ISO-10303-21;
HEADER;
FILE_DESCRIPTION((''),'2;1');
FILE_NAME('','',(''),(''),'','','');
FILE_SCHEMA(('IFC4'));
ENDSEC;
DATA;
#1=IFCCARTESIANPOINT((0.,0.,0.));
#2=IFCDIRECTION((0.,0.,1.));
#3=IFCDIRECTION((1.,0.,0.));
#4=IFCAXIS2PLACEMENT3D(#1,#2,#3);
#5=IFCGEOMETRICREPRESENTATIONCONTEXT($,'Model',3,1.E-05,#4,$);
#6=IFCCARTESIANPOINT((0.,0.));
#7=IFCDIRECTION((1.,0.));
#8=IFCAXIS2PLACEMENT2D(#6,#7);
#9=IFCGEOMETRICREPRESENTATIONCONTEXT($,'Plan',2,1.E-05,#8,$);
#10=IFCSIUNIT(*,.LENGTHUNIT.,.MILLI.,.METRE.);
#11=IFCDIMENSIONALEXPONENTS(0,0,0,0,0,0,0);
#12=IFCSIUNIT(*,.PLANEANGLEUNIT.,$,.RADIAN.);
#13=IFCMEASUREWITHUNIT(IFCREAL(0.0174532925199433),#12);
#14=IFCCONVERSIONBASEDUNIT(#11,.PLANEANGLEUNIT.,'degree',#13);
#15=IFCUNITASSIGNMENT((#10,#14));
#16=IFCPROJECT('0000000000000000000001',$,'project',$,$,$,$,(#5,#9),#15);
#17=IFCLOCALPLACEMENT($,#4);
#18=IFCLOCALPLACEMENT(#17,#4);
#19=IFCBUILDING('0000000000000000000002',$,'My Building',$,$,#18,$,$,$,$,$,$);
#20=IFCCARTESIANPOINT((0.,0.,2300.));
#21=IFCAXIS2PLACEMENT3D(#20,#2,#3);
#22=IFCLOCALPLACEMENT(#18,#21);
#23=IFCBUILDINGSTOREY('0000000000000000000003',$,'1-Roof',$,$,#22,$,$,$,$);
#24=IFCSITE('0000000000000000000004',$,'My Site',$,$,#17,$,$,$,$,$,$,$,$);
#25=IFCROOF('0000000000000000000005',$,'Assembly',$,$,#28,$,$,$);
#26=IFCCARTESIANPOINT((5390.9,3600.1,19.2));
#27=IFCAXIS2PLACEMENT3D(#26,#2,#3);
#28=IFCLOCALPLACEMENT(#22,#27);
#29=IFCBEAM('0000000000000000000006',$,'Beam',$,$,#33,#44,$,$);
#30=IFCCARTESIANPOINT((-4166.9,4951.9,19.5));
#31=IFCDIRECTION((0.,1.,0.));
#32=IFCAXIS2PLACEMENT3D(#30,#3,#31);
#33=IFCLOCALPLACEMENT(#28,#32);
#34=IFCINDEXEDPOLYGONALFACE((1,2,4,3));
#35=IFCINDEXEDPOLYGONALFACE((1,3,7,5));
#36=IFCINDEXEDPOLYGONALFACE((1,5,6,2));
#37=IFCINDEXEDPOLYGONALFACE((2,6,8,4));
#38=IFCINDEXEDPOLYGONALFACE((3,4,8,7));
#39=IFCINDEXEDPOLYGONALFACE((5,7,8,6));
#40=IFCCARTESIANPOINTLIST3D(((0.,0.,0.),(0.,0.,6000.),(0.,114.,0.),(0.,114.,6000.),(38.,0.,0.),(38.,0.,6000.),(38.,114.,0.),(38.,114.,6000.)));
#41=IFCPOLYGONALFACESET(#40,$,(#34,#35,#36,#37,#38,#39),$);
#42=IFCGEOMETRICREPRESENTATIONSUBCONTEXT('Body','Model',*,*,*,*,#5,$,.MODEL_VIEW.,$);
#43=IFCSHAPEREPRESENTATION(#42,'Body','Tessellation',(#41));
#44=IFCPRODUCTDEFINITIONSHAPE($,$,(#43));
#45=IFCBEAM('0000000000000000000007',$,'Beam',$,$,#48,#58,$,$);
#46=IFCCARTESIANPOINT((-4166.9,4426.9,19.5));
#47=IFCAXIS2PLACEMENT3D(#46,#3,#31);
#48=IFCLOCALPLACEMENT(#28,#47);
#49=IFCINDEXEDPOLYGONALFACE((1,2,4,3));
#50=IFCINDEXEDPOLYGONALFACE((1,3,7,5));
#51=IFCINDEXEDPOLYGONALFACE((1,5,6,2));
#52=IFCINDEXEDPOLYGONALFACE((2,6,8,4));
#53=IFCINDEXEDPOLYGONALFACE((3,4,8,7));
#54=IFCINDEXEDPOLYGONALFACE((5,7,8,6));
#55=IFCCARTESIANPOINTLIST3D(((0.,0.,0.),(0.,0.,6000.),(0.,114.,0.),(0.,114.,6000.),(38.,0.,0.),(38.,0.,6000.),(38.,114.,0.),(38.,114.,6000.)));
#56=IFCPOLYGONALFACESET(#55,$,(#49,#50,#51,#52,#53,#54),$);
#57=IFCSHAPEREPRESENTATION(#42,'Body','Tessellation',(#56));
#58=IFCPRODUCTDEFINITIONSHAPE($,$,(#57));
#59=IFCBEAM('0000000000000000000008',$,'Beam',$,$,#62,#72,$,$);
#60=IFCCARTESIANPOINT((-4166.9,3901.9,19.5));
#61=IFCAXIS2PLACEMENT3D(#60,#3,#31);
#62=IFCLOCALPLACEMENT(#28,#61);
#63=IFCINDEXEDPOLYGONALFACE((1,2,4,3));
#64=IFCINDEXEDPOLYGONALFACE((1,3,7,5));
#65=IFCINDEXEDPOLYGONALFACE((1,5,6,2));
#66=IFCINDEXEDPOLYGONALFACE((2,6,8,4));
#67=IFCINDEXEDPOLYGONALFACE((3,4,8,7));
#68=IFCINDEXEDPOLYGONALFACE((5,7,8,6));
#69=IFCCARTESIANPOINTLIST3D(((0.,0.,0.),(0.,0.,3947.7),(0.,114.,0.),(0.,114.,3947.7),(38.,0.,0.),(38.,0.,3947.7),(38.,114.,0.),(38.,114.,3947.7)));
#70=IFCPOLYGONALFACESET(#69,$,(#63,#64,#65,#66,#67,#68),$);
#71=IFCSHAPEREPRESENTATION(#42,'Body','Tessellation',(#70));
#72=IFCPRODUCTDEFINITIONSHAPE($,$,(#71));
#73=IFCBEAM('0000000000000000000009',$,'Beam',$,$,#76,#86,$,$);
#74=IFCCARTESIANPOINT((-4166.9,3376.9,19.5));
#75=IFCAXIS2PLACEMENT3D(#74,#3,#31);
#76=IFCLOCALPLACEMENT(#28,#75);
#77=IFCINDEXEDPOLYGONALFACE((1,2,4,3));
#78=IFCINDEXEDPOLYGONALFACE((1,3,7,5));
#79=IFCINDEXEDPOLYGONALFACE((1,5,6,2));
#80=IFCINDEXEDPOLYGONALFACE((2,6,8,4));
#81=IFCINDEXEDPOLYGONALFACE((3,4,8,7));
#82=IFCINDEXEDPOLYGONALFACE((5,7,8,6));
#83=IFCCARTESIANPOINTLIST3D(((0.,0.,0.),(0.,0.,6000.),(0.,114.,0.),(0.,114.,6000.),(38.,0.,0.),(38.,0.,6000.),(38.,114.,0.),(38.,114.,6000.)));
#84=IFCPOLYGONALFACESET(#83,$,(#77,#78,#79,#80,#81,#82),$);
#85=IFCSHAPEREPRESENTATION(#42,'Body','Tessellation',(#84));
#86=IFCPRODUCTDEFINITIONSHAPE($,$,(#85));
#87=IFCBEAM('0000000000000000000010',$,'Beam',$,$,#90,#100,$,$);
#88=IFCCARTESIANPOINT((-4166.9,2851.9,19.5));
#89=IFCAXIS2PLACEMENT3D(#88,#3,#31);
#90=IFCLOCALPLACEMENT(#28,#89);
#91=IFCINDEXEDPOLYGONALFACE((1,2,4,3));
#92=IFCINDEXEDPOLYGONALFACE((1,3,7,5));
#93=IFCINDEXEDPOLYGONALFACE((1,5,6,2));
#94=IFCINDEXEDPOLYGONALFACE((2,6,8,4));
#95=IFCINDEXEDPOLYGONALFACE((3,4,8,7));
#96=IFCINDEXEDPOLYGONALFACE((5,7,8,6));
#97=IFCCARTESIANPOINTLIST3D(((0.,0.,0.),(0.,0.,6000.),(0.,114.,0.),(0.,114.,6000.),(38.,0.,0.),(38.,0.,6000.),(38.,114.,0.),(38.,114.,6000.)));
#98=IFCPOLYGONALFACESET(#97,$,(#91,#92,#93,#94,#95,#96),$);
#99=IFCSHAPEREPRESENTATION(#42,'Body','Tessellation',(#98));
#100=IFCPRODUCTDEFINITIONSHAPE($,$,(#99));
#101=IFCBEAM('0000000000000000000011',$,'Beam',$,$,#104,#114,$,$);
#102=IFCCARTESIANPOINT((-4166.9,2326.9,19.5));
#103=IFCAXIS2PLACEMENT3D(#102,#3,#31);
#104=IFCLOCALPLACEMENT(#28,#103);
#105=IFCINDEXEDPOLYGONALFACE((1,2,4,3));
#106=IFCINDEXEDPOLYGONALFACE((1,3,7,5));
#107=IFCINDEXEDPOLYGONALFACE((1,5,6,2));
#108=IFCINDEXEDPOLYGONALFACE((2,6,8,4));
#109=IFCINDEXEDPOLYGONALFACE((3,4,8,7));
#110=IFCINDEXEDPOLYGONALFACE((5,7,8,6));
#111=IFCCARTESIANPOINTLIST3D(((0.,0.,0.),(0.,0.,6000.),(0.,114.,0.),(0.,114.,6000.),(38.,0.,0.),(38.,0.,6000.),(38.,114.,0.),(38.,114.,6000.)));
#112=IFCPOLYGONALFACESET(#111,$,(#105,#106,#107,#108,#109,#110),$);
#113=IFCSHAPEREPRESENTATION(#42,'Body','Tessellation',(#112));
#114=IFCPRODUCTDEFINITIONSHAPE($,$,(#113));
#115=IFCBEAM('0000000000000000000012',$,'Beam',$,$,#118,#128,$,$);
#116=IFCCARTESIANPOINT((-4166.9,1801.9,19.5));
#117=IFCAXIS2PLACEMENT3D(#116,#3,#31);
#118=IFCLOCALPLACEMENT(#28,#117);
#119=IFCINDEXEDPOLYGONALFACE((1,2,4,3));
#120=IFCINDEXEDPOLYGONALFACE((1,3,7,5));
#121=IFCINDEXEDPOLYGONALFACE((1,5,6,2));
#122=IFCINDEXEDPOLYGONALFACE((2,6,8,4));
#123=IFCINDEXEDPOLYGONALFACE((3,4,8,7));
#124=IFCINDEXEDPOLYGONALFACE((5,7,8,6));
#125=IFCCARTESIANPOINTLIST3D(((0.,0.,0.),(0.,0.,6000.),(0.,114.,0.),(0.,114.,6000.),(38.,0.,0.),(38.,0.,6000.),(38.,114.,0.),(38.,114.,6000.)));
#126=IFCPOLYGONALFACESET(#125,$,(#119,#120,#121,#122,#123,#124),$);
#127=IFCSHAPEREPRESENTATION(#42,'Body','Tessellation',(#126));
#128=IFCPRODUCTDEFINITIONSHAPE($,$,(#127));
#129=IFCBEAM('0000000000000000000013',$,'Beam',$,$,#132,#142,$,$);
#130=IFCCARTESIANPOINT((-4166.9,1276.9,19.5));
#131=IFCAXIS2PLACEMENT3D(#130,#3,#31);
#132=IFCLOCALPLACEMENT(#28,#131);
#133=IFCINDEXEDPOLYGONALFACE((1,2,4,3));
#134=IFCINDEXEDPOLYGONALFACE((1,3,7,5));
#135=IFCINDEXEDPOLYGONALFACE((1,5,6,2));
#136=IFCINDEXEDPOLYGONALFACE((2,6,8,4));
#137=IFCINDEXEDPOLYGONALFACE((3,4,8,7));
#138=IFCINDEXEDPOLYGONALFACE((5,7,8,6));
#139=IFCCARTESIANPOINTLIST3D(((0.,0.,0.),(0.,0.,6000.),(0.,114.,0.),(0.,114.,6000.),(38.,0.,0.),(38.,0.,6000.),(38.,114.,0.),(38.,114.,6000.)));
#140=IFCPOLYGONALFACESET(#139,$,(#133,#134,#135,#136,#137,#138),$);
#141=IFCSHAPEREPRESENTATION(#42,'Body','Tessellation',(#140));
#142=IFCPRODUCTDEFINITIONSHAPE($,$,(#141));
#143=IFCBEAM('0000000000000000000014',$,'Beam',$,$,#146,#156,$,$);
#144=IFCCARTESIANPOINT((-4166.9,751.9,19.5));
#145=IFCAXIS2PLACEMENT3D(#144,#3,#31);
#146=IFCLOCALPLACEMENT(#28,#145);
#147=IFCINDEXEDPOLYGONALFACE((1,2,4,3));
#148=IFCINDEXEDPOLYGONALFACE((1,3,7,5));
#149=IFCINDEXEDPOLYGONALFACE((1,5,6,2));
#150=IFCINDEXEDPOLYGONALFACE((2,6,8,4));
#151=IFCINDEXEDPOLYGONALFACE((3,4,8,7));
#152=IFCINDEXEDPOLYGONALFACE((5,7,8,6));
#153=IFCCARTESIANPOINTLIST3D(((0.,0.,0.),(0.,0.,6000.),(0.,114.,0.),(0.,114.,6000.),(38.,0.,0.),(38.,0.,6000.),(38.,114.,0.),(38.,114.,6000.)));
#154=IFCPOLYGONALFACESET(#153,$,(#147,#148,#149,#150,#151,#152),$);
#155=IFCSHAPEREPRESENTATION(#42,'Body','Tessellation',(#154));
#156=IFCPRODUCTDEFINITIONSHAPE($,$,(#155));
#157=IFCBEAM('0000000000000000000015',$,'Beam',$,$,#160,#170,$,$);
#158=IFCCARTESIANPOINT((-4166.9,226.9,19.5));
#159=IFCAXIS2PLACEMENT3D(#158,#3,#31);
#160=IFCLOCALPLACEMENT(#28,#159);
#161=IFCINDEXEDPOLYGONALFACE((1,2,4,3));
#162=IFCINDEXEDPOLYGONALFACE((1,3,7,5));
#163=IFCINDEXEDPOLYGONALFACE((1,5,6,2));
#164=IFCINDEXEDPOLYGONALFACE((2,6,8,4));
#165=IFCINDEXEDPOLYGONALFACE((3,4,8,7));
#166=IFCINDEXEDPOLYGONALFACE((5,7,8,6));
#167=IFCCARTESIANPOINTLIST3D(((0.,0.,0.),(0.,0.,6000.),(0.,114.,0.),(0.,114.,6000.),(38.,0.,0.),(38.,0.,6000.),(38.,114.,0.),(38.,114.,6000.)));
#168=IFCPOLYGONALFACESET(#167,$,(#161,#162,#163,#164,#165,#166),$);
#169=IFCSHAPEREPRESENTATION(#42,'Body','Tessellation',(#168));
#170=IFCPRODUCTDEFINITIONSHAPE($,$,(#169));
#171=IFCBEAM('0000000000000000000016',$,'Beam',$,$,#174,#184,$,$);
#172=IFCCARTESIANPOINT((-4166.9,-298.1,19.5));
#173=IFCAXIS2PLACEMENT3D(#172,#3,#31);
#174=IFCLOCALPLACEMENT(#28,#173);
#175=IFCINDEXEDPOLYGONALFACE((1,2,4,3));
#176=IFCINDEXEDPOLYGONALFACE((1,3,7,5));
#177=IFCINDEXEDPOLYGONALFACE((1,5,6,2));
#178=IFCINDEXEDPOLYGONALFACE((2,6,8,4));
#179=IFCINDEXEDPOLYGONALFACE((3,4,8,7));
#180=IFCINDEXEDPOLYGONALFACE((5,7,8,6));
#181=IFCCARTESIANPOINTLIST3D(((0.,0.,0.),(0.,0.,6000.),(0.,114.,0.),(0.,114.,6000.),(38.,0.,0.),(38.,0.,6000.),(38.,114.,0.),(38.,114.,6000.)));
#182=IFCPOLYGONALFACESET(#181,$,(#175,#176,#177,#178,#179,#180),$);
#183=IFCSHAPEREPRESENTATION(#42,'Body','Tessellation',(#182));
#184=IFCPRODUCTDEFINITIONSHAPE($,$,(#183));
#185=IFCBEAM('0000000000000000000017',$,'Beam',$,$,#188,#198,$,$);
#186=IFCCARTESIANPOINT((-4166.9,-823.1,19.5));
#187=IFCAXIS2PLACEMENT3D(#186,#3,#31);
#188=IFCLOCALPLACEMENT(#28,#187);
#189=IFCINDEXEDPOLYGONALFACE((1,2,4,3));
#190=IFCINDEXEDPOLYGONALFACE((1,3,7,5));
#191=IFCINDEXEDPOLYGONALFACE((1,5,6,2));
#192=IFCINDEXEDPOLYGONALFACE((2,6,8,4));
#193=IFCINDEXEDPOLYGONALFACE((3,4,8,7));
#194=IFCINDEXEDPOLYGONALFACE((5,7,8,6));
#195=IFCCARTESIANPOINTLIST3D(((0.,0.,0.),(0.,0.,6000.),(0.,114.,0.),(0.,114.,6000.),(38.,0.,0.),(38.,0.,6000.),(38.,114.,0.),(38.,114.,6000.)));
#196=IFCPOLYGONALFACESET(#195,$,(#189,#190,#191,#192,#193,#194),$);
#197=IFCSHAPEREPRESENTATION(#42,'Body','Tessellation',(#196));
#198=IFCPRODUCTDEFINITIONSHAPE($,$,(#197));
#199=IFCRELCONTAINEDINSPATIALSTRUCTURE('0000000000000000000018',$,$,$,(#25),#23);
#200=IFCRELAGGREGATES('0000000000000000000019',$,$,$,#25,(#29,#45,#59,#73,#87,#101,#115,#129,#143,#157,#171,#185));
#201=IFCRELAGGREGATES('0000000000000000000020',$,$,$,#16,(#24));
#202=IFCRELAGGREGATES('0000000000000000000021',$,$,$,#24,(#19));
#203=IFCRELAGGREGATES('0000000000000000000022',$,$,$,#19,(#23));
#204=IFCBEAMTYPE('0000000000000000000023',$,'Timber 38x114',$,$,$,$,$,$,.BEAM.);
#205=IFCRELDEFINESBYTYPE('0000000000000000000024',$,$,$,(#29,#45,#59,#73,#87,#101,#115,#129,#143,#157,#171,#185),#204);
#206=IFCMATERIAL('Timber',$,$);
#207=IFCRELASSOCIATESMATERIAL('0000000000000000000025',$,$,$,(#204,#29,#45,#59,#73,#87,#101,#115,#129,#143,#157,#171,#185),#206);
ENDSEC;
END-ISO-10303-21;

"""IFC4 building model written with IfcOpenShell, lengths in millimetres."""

from ifc_helpers import new_model, entity, si_unit, converted_unit, frame, origin_with_axes, origin_2d_with_axis, place, context, subcontext, project, spatial, line, indexed_curve, outline, extrude, material, material_profile, profile_set, profile_usage, type_object, element, aggregate, save


model = new_model("IFC4")

# Units and contexts
model_context = context("Model", 3, precision=1e-05, world=origin_with_axes())
plan_context = context("Plan", 2, precision=1e-05, world=origin_2d_with_axis())
body_context = subcontext(model_context, "Body", "Model", "MODEL_VIEW")
ifc_project = project(units=[si_unit("LENGTHUNIT", "METRE", prefix="MILLI"), converted_unit("PLANEANGLEUNIT", "degree", entity("IfcReal", 0.0174532925199433), si_unit("PLANEANGLEUNIT", "RADIAN"), dimensions=[0, 0, 0, 0, 0, 0, 0])], contexts=[model_context, plan_context])

# Site, building, storey
site_placement = place(None, origin_with_axes())
site = spatial("IfcSite", under=ifc_project, at=site_placement, Name="My Site")
building_placement = place(site_placement, origin_with_axes())
building = spatial("IfcBuilding", under=site, at=building_placement, Name="My Building")
storey_placement = place(building_placement, frame((0.0, 0.0, 2300.0), z_axis=(0.0, 0.0, 1.0), x_axis=(1.0, 0.0, 0.0)))
storey = spatial("IfcBuildingStorey", under=building, at=storey_placement, Name="1-Roof")

# Roof, beams
roof_placement = place(storey_placement, frame((5390.9, 3600.1, 19.2), z_axis=(0.0, 0.0, 1.0), x_axis=(1.0, 0.0, 0.0)))
roof = element("IfcRoof", 1, at=roof_placement, inside=storey, Name="Assembly")
ifc_material_1 = material(Name="Timber")
ifc_material_profile_1 = material_profile(ifc_material_1, outline(indexed_curve([(0.0, 0.0), (38.0, 0.0), (38.0, 114.0), (0.0, 114.0)], segments=[line(3, 2), line(2, 1), line(1, 4), line(4, 3)], self_intersect=False)))
ifc_profile_set_1 = profile_set([ifc_material_profile_1])
ifc_profile_usage_1 = profile_usage(ifc_profile_set_1, cardinal=5)
beam_type_1 = type_object("IfcBeamType", Name="Timber 38x114", PredefinedType="BEAM", material=ifc_profile_set_1)
beam_1_placement = place(roof_placement, frame((-4166.9, 4951.9, 19.5), z_axis=(1.0, 0.0, 0.0), x_axis=(0.0, 1.0, 0.0)))
beam_1 = element("IfcBeam", 2, at=beam_1_placement, type_object=beam_type_1, material=ifc_profile_usage_1, Name="Beam", context=body_context, shape_type="SweptSolid", body=[
    extrude(outline(indexed_curve([(0.0, 0.0), (38.0, 0.0), (38.0, 114.0), (0.0, 114.0)], segments=[line(3, 2), line(2, 1), line(1, 4), line(4, 3)], self_intersect=False)), origin_with_axes(), (0.0, 0.0, 1.0), 6000.0),
])
ifc_profile_usage_2 = profile_usage(ifc_profile_set_1, cardinal=5)
beam_2_placement = place(roof_placement, frame((-4166.9, 4426.9, 19.5), z_axis=(1.0, 0.0, 0.0), x_axis=(0.0, 1.0, 0.0)))
beam_2 = element("IfcBeam", 3, at=beam_2_placement, type_object=beam_type_1, material=ifc_profile_usage_2, Name="Beam", context=body_context, shape_type="SweptSolid", body=[
    extrude(outline(indexed_curve([(0.0, 0.0), (38.0, 0.0), (38.0, 114.0), (0.0, 114.0)], segments=[line(3, 2), line(2, 1), line(1, 4), line(4, 3)], self_intersect=False)), origin_with_axes(), (0.0, 0.0, 1.0), 6000.0),
])
ifc_profile_usage_3 = profile_usage(ifc_profile_set_1, cardinal=5)
beam_3_placement = place(roof_placement, frame((-4166.9, 3901.9, 19.5), z_axis=(1.0, 0.0, 0.0), x_axis=(0.0, 1.0, 0.0)))
beam_3 = element("IfcBeam", 4, at=beam_3_placement, type_object=beam_type_1, material=ifc_profile_usage_3, Name="Beam", context=body_context, shape_type="SweptSolid", body=[
    extrude(outline(indexed_curve([(0.0, 0.0), (38.0, 0.0), (38.0, 114.0), (0.0, 114.0)], segments=[line(3, 2), line(2, 1), line(1, 4), line(4, 3)], self_intersect=False)), origin_with_axes(), (0.0, 0.0, 1.0), 3947.7),
])
ifc_profile_usage_4 = profile_usage(ifc_profile_set_1, cardinal=5)
beam_4_placement = place(roof_placement, frame((-4166.9, 3376.9, 19.5), z_axis=(1.0, 0.0, 0.0), x_axis=(0.0, 1.0, 0.0)))
beam_4 = element("IfcBeam", 5, at=beam_4_placement, type_object=beam_type_1, material=ifc_profile_usage_4, Name="Beam", context=body_context, shape_type="SweptSolid", body=[
    extrude(outline(indexed_curve([(0.0, 0.0), (38.0, 0.0), (38.0, 114.0), (0.0, 114.0)], segments=[line(3, 2), line(2, 1), line(1, 4), line(4, 3)], self_intersect=False)), origin_with_axes(), (0.0, 0.0, 1.0), 6000.0),
])
ifc_profile_usage_5 = profile_usage(ifc_profile_set_1, cardinal=5)
beam_5_placement = place(roof_placement, frame((-4166.9, 2851.9, 19.5), z_axis=(1.0, 0.0, 0.0), x_axis=(0.0, 1.0, 0.0)))
beam_5 = element("IfcBeam", 6, at=beam_5_placement, type_object=beam_type_1, material=ifc_profile_usage_5, Name="Beam", context=body_context, shape_type="SweptSolid", body=[
    extrude(outline(indexed_curve([(0.0, 0.0), (38.0, 0.0), (38.0, 114.0), (0.0, 114.0)], segments=[line(3, 2), line(2, 1), line(1, 4), line(4, 3)], self_intersect=False)), origin_with_axes(), (0.0, 0.0, 1.0), 6000.0),
])
ifc_profile_usage_6 = profile_usage(ifc_profile_set_1, cardinal=5)
beam_6_placement = place(roof_placement, frame((-4166.9, 2326.9, 19.5), z_axis=(1.0, 0.0, 0.0), x_axis=(0.0, 1.0, 0.0)))
beam_6 = element("IfcBeam", 7, at=beam_6_placement, type_object=beam_type_1, material=ifc_profile_usage_6, Name="Beam", context=body_context, shape_type="SweptSolid", body=[
    extrude(outline(indexed_curve([(0.0, 0.0), (38.0, 0.0), (38.0, 114.0), (0.0, 114.0)], segments=[line(3, 2), line(2, 1), line(1, 4), line(4, 3)], self_intersect=False)), origin_with_axes(), (0.0, 0.0, 1.0), 6000.0),
])
ifc_profile_usage_7 = profile_usage(ifc_profile_set_1, cardinal=5)
beam_7_placement = place(roof_placement, frame((-4166.9, 1801.9, 19.5), z_axis=(1.0, 0.0, 0.0), x_axis=(0.0, 1.0, 0.0)))
beam_7 = element("IfcBeam", 8, at=beam_7_placement, type_object=beam_type_1, material=ifc_profile_usage_7, Name="Beam", context=body_context, shape_type="SweptSolid", body=[
    extrude(outline(indexed_curve([(0.0, 0.0), (38.0, 0.0), (38.0, 114.0), (0.0, 114.0)], segments=[line(3, 2), line(2, 1), line(1, 4), line(4, 3)], self_intersect=False)), origin_with_axes(), (0.0, 0.0, 1.0), 6000.0),
])
ifc_profile_usage_8 = profile_usage(ifc_profile_set_1, cardinal=5)
beam_8_placement = place(roof_placement, frame((-4166.9, 1276.9, 19.5), z_axis=(1.0, 0.0, 0.0), x_axis=(0.0, 1.0, 0.0)))
beam_8 = element("IfcBeam", 9, at=beam_8_placement, type_object=beam_type_1, material=ifc_profile_usage_8, Name="Beam", context=body_context, shape_type="SweptSolid", body=[
    extrude(outline(indexed_curve([(0.0, 0.0), (38.0, 0.0), (38.0, 114.0), (0.0, 114.0)], segments=[line(3, 2), line(2, 1), line(1, 4), line(4, 3)], self_intersect=False)), origin_with_axes(), (0.0, 0.0, 1.0), 6000.0),
])
ifc_profile_usage_9 = profile_usage(ifc_profile_set_1, cardinal=5)
beam_9_placement = place(roof_placement, frame((-4166.9, 751.9, 19.5), z_axis=(1.0, 0.0, 0.0), x_axis=(0.0, 1.0, 0.0)))
beam_9 = element("IfcBeam", 10, at=beam_9_placement, type_object=beam_type_1, material=ifc_profile_usage_9, Name="Beam", context=body_context, shape_type="SweptSolid", body=[
    extrude(outline(indexed_curve([(0.0, 0.0), (38.0, 0.0), (38.0, 114.0), (0.0, 114.0)], segments=[line(3, 2), line(2, 1), line(1, 4), line(4, 3)], self_intersect=False)), origin_with_axes(), (0.0, 0.0, 1.0), 6000.0),
])
ifc_profile_usage_10 = profile_usage(ifc_profile_set_1, cardinal=5)
beam_10_placement = place(roof_placement, frame((-4166.9, 226.9, 19.5), z_axis=(1.0, 0.0, 0.0), x_axis=(0.0, 1.0, 0.0)))
beam_10 = element("IfcBeam", 11, at=beam_10_placement, type_object=beam_type_1, material=ifc_profile_usage_10, Name="Beam", context=body_context, shape_type="SweptSolid", body=[
    extrude(outline(indexed_curve([(0.0, 0.0), (38.0, 0.0), (38.0, 114.0), (0.0, 114.0)], segments=[line(3, 2), line(2, 1), line(1, 4), line(4, 3)], self_intersect=False)), origin_with_axes(), (0.0, 0.0, 1.0), 6000.0),
])
ifc_profile_usage_11 = profile_usage(ifc_profile_set_1, cardinal=5)
beam_11_placement = place(roof_placement, frame((-4166.9, -298.1, 19.5), z_axis=(1.0, 0.0, 0.0), x_axis=(0.0, 1.0, 0.0)))
beam_11 = element("IfcBeam", 12, at=beam_11_placement, type_object=beam_type_1, material=ifc_profile_usage_11, Name="Beam", context=body_context, shape_type="SweptSolid", body=[
    extrude(outline(indexed_curve([(0.0, 0.0), (38.0, 0.0), (38.0, 114.0), (0.0, 114.0)], segments=[line(3, 2), line(2, 1), line(1, 4), line(4, 3)], self_intersect=False)), origin_with_axes(), (0.0, 0.0, 1.0), 6000.0),
])
ifc_profile_usage_12 = profile_usage(ifc_profile_set_1, cardinal=5)
beam_12_placement = place(roof_placement, frame((-4166.9, -823.1, 19.5), z_axis=(1.0, 0.0, 0.0), x_axis=(0.0, 1.0, 0.0)))
beam_12 = element("IfcBeam", 13, at=beam_12_placement, type_object=beam_type_1, material=ifc_profile_usage_12, Name="Beam", context=body_context, shape_type="SweptSolid", body=[
    extrude(outline(indexed_curve([(0.0, 0.0), (38.0, 0.0), (38.0, 114.0), (0.0, 114.0)], segments=[line(3, 2), line(2, 1), line(1, 4), line(4, 3)], self_intersect=False)), origin_with_axes(), (0.0, 0.0, 1.0), 6000.0),
])
aggregate(roof, [beam_1, beam_2, beam_3, beam_4, beam_5, beam_6, beam_7, beam_8, beam_9, beam_10, beam_11, beam_12])

save(model, "model.ifc")
